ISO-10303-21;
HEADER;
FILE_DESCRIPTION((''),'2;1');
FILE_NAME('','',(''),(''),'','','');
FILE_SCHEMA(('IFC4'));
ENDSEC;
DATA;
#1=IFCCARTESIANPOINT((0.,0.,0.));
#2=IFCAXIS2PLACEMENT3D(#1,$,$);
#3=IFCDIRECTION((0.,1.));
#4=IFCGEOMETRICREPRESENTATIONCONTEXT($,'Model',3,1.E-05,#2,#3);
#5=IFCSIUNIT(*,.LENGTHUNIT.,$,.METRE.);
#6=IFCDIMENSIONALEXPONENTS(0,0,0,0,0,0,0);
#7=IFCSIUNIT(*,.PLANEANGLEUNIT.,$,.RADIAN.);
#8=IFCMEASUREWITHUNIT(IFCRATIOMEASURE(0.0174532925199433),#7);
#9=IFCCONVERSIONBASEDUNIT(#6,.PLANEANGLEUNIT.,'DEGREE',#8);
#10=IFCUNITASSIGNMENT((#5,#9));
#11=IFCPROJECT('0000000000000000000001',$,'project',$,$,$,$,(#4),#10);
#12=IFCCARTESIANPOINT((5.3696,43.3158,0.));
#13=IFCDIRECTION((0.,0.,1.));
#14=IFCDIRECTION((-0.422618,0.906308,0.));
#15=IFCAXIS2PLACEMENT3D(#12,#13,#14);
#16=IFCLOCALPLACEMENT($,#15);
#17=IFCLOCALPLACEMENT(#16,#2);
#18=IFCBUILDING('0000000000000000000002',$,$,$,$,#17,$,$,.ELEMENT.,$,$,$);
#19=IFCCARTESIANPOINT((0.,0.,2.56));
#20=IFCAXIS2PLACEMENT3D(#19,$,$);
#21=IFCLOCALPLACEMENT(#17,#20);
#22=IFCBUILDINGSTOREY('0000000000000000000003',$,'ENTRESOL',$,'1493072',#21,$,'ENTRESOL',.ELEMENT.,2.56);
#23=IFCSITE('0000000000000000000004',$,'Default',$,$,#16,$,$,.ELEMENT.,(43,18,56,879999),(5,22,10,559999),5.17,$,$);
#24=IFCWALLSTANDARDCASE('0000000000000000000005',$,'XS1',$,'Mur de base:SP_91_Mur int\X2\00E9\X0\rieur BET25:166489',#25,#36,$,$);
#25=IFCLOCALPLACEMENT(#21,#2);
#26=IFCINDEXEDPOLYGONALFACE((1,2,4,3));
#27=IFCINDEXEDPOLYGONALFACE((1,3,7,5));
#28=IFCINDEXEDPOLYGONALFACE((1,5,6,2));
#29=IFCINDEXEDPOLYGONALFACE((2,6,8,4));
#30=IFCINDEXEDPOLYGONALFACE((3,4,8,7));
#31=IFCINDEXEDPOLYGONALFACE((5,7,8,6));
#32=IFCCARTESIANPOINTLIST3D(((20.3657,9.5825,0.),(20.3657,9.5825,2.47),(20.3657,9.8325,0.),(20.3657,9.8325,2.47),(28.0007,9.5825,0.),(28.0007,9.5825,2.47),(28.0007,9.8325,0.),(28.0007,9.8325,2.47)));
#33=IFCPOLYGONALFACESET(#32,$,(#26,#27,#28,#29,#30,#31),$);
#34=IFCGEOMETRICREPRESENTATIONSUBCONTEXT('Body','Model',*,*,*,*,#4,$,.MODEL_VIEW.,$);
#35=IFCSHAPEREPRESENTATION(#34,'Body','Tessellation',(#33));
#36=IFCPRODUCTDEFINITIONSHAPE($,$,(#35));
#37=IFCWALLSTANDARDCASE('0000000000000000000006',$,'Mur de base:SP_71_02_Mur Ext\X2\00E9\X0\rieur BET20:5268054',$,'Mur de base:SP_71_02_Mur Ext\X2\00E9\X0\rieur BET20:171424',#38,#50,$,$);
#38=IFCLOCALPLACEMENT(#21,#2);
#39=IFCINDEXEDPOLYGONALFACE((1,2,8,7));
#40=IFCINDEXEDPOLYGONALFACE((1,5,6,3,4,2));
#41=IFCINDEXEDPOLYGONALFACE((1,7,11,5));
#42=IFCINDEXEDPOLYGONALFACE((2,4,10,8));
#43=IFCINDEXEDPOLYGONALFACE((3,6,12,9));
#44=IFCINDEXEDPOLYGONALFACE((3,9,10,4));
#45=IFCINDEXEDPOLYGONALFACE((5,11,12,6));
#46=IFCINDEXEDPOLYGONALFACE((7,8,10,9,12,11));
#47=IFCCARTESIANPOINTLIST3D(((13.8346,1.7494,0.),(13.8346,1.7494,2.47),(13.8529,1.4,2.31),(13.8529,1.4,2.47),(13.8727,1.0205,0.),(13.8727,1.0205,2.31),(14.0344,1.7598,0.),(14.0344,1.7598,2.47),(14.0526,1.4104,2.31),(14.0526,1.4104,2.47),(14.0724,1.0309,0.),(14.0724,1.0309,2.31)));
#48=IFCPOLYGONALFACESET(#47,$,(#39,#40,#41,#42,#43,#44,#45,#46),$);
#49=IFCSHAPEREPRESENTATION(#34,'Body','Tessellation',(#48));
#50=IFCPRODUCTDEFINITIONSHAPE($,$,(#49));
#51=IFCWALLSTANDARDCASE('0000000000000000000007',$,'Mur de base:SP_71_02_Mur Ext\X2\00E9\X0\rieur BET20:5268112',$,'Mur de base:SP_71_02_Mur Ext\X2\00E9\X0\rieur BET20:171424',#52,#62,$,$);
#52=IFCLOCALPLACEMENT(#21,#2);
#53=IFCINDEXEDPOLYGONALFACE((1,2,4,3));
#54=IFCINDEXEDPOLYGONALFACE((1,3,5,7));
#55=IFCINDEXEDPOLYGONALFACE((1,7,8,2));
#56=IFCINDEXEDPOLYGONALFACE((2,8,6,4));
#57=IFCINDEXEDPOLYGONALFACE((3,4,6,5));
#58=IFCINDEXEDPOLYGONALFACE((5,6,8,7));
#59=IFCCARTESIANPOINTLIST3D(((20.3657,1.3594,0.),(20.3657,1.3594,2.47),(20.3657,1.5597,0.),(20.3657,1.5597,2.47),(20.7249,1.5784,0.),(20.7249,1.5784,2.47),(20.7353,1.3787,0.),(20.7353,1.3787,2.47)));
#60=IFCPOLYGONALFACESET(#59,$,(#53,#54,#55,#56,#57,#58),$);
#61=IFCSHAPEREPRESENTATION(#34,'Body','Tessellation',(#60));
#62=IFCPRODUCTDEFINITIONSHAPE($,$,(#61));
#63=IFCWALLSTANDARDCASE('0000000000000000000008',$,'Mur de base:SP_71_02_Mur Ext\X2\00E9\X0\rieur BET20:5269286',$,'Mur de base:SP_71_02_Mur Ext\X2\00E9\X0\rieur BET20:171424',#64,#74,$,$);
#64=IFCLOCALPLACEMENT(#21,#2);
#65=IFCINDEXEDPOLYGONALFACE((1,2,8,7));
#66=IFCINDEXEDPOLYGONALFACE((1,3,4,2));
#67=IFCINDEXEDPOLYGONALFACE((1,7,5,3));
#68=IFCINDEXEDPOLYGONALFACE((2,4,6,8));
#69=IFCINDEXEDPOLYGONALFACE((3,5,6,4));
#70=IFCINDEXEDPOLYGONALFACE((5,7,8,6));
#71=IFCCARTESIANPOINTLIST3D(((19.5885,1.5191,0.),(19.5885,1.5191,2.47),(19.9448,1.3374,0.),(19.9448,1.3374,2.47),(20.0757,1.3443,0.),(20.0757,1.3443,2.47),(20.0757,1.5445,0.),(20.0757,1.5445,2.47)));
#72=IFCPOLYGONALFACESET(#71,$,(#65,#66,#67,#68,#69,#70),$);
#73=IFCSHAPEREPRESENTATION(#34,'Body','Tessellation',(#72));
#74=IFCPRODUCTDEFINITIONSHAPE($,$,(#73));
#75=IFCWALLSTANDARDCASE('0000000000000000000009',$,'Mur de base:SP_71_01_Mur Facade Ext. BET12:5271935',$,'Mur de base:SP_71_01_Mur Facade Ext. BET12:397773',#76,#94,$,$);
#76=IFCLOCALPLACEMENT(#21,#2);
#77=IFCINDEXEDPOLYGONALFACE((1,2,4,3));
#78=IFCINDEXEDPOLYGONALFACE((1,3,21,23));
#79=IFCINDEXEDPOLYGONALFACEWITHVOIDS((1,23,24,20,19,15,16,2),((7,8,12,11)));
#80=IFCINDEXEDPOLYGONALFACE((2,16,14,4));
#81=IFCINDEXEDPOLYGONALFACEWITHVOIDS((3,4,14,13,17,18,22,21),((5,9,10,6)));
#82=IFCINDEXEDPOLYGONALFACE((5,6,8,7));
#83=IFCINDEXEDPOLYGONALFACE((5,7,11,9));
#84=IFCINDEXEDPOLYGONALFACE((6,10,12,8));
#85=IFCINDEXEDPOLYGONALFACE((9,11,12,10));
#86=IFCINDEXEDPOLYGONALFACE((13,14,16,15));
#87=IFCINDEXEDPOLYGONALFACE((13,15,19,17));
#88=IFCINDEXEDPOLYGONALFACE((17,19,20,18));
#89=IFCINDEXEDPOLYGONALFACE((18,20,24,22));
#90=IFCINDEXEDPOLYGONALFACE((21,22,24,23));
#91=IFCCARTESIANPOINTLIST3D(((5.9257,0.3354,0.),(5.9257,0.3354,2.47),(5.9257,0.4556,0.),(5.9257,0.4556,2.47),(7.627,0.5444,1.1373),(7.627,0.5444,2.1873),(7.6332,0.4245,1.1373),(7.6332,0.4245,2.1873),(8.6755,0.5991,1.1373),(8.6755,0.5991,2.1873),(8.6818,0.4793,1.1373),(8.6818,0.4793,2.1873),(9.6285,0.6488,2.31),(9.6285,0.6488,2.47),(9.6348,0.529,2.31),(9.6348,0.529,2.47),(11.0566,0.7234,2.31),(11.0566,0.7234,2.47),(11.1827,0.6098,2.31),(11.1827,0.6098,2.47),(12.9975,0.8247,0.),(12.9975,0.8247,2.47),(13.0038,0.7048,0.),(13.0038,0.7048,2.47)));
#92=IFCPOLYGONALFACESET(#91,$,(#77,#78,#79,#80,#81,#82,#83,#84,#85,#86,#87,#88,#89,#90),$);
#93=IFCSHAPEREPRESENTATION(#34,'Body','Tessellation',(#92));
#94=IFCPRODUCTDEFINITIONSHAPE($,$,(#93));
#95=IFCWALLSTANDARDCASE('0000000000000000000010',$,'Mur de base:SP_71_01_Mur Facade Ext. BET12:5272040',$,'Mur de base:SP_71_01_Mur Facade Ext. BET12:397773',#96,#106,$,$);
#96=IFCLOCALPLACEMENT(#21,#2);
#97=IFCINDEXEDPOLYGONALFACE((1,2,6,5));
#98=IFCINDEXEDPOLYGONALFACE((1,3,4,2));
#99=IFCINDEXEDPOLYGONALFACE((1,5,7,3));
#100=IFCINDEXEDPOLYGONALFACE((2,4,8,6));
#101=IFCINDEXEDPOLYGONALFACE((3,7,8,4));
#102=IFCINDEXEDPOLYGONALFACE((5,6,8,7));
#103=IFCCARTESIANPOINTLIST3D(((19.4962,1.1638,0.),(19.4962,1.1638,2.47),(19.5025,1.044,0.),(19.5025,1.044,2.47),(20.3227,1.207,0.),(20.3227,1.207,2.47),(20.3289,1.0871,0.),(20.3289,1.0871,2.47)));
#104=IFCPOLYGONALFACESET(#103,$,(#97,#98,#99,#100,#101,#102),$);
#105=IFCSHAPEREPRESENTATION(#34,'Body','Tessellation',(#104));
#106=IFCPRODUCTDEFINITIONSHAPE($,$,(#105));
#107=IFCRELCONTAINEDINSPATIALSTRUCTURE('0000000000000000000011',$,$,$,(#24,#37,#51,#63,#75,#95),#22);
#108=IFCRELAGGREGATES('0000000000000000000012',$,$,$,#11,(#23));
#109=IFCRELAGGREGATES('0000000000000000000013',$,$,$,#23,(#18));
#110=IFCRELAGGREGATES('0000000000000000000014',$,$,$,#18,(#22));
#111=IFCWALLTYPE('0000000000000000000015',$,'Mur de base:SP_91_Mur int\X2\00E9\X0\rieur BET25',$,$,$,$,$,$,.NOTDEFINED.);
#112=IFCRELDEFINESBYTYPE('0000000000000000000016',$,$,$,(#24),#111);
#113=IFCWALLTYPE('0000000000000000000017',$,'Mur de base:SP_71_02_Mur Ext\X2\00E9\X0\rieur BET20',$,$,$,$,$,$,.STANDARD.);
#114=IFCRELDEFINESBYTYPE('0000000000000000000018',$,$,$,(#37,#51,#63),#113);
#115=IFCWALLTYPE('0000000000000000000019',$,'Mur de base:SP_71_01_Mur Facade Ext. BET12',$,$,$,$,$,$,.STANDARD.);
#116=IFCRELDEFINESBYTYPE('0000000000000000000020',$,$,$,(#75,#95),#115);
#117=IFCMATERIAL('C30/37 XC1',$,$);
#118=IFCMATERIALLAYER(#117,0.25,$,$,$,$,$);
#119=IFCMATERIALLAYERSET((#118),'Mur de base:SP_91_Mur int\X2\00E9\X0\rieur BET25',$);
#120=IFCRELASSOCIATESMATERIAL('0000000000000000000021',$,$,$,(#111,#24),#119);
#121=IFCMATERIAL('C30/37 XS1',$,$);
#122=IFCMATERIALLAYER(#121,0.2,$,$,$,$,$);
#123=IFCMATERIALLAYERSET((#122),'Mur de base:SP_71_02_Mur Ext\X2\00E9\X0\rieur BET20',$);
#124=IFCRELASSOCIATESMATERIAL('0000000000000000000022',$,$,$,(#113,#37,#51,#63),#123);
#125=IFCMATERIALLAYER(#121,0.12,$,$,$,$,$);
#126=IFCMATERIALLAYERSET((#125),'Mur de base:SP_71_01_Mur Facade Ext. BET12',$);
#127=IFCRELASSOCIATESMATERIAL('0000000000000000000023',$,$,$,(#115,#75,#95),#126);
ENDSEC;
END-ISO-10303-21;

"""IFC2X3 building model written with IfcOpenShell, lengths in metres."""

from ifc_helpers import new_model, entity, si_unit, converted_unit, direction, frame, frame_2d, origin, place, context, subcontext, project, spatial, polyline, rectangle, outline, extrude, clip, halfspace, bounded_halfspace, material, layer, layer_set, layer_usage, type_object, element, save


model = new_model("IFC2X3")

# Units and contexts
model_context = context("Model", 3, precision=1e-05, world=origin(), true_north=direction((0.0, 1.0)))
body_context = subcontext(model_context, "Body", "Model", "MODEL_VIEW")
ifc_project = project(units=[si_unit("LENGTHUNIT", "METRE"), converted_unit("PLANEANGLEUNIT", "DEGREE", entity("IfcRatioMeasure", 0.0174532925199433), si_unit("PLANEANGLEUNIT", "RADIAN"), dimensions=[0, 0, 0, 0, 0, 0, 0])], contexts=[model_context])

# Site, building, storey
site_placement = place(None, frame((5.3696, 43.3158, 0.0), z_axis=(0.0, 0.0, 1.0), x_axis=(-0.422618, 0.906308, 0.0)))
site = spatial("IfcSite", under=ifc_project, at=site_placement, Name="Default", CompositionType="ELEMENT", RefLatitude=(43, 18, 56, 879999), RefLongitude=(5, 22, 10, 559999), RefElevation=5.17)
building_placement = place(site_placement, origin())
building = spatial("IfcBuilding", under=site, at=building_placement, CompositionType="ELEMENT")
storey_placement = place(building_placement, frame((0.0, 0.0, 2.56)))
storey = spatial("IfcBuildingStorey", under=building, at=storey_placement, Name="ENTRESOL", ObjectType="1493072", LongName="ENTRESOL", CompositionType="ELEMENT", Elevation=2.56)

# Wall
ifc_material_1 = material(Name="C30/37 XC1")
ifc_layer_1 = layer(ifc_material_1, 0.25)
ifc_layer_set_1 = layer_set([ifc_layer_1], Name="Mur de base:SP_91_Mur intérieur BET25")
ifc_layer_usage_1 = layer_usage(ifc_layer_set_1, "AXIS2", "NEGATIVE", 0.125)
wall_type_1 = type_object("IfcWallType", Name="Mur de base:SP_91_Mur intérieur BET25", PredefinedType="NOTDEFINED", material=ifc_layer_set_1)
wall_1_placement = place(storey_placement, frame((20.3657, 9.7075, 0.0)))
element("IfcWallStandardCase", 1, at=wall_1_placement, inside=storey, type_object=wall_type_1, material=ifc_layer_usage_1, Name="XS1", ObjectType="Mur de base:SP_91_Mur intérieur BET25:166489", context=body_context, shape_type="Clipping", body=[
    clip(extrude(rectangle(XDim=7.635, YDim=0.25, at=frame_2d((3.8175, 0.0), x_axis=(-1.0, 0.0))), origin(), (0.0, 0.0, 1.0), 2.47), halfspace(frame((0.0, 0.0, -2.56)), True)),
])

# Shared definitions
ifc_material_2 = material(Name="C30/37 XS1")
ifc_layer_2 = layer(ifc_material_2, 0.2)
ifc_layer_set_2 = layer_set([ifc_layer_2], Name="Mur de base:SP_71_02_Mur Extérieur BET20")
wall_type_2 = type_object("IfcWallType", Name="Mur de base:SP_71_02_Mur Extérieur BET20", PredefinedType="STANDARD", material=ifc_layer_set_2)

# Walls
ifc_layer_usage_2 = layer_usage(ifc_layer_set_2, "AXIS2", "NEGATIVE", 0.1)
wall_2_placement = place(storey_placement, frame((13.9725, 1.0257, 0.0), z_axis=(0.0, 0.0, 1.0), x_axis=(-0.05212, 0.998641, 0.0)))
element("IfcWallStandardCase", 2, at=wall_2_placement, inside=storey, type_object=wall_type_2, material=ifc_layer_usage_2, Name="Mur de base:SP_71_02_Mur Extérieur BET20:5268054", ObjectType="Mur de base:SP_71_02_Mur Extérieur BET20:171424", context=body_context, shape_type="Clipping", body=[
    clip(clip(clip(clip(extrude(rectangle(XDim=0.7299, YDim=0.2, at=frame_2d((0.3649, 0.0), x_axis=(-1.0, 0.0))), origin(), (0.0, 0.0, 1.0), 2.47), bounded_halfspace(frame((0.5652, -0.1, 2.47), z_axis=(0.0, 0.0, -1.0), x_axis=(-1.0, -0.000001, 0.0)), True, frame((0.5652, -0.1, 2.47)), polyline([(0.0, 0.0), (0.0, 0.2), (-0.1852, 0.2), (-0.1852, 0.0), (-0.0353, 0.0), (0.0, 0.0)]))), bounded_halfspace(frame((0.38, -0.1, 2.31), z_axis=(0.0, 0.0, -1.0), x_axis=(0.0, -1.0, 0.0)), True, frame((0.38, -0.1, 2.31), z_axis=(0.0, 0.0, -1.0), x_axis=(0.0, -1.0, 0.0)), polyline([(0.0, 0.0), (0.0, 0.38), (-0.2, 0.38), (-0.2, 0.18), (-0.2, 0.0), (0.0, 0.0)]))), bounded_halfspace(frame((0.38, 0.1, 2.31), z_axis=(1.0, 0.0, 0.0), x_axis=(0.0, 0.0, 1.0)), True, frame((0.38, 0.1, 2.31), z_axis=(1.0, 0.0, 0.0), x_axis=(0.0, 0.0, 1.0)), polyline([(0.0, 0.0), (0.16, 0.0), (0.16, 0.2), (0.0, 0.2), (0.0, 0.0)]))), halfspace(frame((0.0, 0.0, -2.56)), True)),
])
ifc_layer_usage_3 = layer_usage(ifc_layer_set_2, "AXIS2", "NEGATIVE", 0.1)
wall_3_placement = place(storey_placement, frame((20.3604, 1.4593, 0.0), z_axis=(0.0, 0.0, 1.0), x_axis=(0.998641, 0.05212, 0.0)))
element("IfcWallStandardCase", 3, at=wall_3_placement, inside=storey, type_object=wall_type_2, material=ifc_layer_usage_3, Name="Mur de base:SP_71_02_Mur Extérieur BET20:5268112", ObjectType="Mur de base:SP_71_02_Mur Extérieur BET20:171424", context=body_context, shape_type="Clipping", body=[
    clip(extrude(outline(polyline([(0.3702, -0.1), (0.3702, 0.1), (0.0104, 0.1), (0.0, -0.1), (0.3702, -0.1)])), origin(), (0.0, 0.0, 1.0), 2.47), halfspace(frame((0.0, 0.0, -2.56)), True)),
])
ifc_layer_usage_4 = layer_usage(ifc_layer_set_2, "AXIS2", "NEGATIVE", 0.1)
wall_4_placement = place(storey_placement, frame((19.5937, 1.4192, 0.0), z_axis=(0.0, 0.0, 1.0), x_axis=(0.998641, 0.052122, 0.0)))
element("IfcWallStandardCase", 4, at=wall_4_placement, inside=storey, type_object=wall_type_2, material=ifc_layer_usage_4, Name="Mur de base:SP_71_02_Mur Extérieur BET20:5269286", ObjectType="Mur de base:SP_71_02_Mur Extérieur BET20:171424", context=body_context, shape_type="Clipping", body=[
    clip(extrude(outline(polyline([(0.4774, -0.1), (0.4878, 0.1), (0.0, 0.1), (0.1511, 0.0128), (0.3464, -0.1), (0.4774, -0.1)])), origin(), (0.0, 0.0, 1.0), 2.47), halfspace(frame((0.0, 0.0, -2.56)), True)),
])
ifc_layer_3 = layer(ifc_material_2, 0.12)
ifc_layer_set_3 = layer_set([ifc_layer_3], Name="Mur de base:SP_71_01_Mur Facade Ext. BET12")
wall_type_3 = type_object("IfcWallType", Name="Mur de base:SP_71_01_Mur Facade Ext. BET12", PredefinedType="STANDARD", material=ifc_layer_set_3)

# Wall, opening
ifc_layer_usage_5 = layer_usage(ifc_layer_set_3, "AXIS2", "NEGATIVE", 0.06)
wall_5_placement = place(storey_placement, frame((13.0007, 0.7648, 0.0), z_axis=(0.0, 0.0, 1.0), x_axis=(-0.998641, -0.05212, 0.0)))
wall_5 = element("IfcWallStandardCase", 5, at=wall_5_placement, inside=storey, type_object=wall_type_3, material=ifc_layer_usage_5, Name="Mur de base:SP_71_01_Mur Facade Ext. BET12:5271935", ObjectType="Mur de base:SP_71_01_Mur Facade Ext. BET12:397773", context=body_context, shape_type="Clipping", body=[
    clip(clip(extrude(outline(polyline([(7.0815, -0.06), (7.0878, 0.06), (0.1283, 0.06), (0.0, 0.06), (0.0, -0.06), (0.122, -0.06), (7.0815, -0.06)])), origin(), (0.0, 0.0, 1.0), 2.47), bounded_halfspace(frame((3.3736, -0.06, 2.31), z_axis=(0.0, 0.0, -1.0), x_axis=(-1.0, 0.0, 0.0)), True, frame((3.3736, -0.06, 2.31), z_axis=(0.0, 0.0, -1.0), x_axis=(-1.0, 0.0, 0.0)), polyline([(0.0, 0.0), (1.43, 0.0), (1.55, 0.12), (0.0, 0.12), (0.0, 0.0)]))), halfspace(frame((0.0, 0.0, -2.56)), True)),
])
opening_1_placement = place(wall_5_placement, origin())
element("IfcOpeningElement", 6, at=opening_1_placement, cuts=wall_5, ObjectType="Opening", context=body_context, shape_type="SweptSolid", body=[
    extrude(rectangle(XDim=1.05, YDim=1.05, at=frame_2d((0.0, 0.0), x_axis=(0.0, 1.0))), frame((4.8529, -1.464, 1.6623), z_axis=(0.0, 1.0, 0.0), x_axis=(-1.0, 0.0, 0.0)), (0.0, 0.0, 1.0), 3.048),
])

# Wall
ifc_layer_usage_6 = layer_usage(ifc_layer_set_3, "AXIS2", "NEGATIVE", 0.06)
wall_6_placement = place(storey_placement, frame((20.3258, 1.1471, 0.0), z_axis=(0.0, 0.0, 1.0), x_axis=(-0.998641, -0.052122, 0.0)))
element("IfcWallStandardCase", 7, at=wall_6_placement, inside=storey, type_object=wall_type_3, material=ifc_layer_usage_6, Name="Mur de base:SP_71_01_Mur Facade Ext. BET12:5272040", ObjectType="Mur de base:SP_71_01_Mur Facade Ext. BET12:397773", context=body_context, shape_type="Clipping", body=[
    clip(extrude(rectangle(XDim=0.8276, YDim=0.12, at=frame_2d((0.4138, 0.0), x_axis=(-1.0, 0.0))), origin(), (0.0, 0.0, 1.0), 2.47), halfspace(frame((0.0, 0.0, -2.56)), True)),
])

save(model, "model.ifc")
